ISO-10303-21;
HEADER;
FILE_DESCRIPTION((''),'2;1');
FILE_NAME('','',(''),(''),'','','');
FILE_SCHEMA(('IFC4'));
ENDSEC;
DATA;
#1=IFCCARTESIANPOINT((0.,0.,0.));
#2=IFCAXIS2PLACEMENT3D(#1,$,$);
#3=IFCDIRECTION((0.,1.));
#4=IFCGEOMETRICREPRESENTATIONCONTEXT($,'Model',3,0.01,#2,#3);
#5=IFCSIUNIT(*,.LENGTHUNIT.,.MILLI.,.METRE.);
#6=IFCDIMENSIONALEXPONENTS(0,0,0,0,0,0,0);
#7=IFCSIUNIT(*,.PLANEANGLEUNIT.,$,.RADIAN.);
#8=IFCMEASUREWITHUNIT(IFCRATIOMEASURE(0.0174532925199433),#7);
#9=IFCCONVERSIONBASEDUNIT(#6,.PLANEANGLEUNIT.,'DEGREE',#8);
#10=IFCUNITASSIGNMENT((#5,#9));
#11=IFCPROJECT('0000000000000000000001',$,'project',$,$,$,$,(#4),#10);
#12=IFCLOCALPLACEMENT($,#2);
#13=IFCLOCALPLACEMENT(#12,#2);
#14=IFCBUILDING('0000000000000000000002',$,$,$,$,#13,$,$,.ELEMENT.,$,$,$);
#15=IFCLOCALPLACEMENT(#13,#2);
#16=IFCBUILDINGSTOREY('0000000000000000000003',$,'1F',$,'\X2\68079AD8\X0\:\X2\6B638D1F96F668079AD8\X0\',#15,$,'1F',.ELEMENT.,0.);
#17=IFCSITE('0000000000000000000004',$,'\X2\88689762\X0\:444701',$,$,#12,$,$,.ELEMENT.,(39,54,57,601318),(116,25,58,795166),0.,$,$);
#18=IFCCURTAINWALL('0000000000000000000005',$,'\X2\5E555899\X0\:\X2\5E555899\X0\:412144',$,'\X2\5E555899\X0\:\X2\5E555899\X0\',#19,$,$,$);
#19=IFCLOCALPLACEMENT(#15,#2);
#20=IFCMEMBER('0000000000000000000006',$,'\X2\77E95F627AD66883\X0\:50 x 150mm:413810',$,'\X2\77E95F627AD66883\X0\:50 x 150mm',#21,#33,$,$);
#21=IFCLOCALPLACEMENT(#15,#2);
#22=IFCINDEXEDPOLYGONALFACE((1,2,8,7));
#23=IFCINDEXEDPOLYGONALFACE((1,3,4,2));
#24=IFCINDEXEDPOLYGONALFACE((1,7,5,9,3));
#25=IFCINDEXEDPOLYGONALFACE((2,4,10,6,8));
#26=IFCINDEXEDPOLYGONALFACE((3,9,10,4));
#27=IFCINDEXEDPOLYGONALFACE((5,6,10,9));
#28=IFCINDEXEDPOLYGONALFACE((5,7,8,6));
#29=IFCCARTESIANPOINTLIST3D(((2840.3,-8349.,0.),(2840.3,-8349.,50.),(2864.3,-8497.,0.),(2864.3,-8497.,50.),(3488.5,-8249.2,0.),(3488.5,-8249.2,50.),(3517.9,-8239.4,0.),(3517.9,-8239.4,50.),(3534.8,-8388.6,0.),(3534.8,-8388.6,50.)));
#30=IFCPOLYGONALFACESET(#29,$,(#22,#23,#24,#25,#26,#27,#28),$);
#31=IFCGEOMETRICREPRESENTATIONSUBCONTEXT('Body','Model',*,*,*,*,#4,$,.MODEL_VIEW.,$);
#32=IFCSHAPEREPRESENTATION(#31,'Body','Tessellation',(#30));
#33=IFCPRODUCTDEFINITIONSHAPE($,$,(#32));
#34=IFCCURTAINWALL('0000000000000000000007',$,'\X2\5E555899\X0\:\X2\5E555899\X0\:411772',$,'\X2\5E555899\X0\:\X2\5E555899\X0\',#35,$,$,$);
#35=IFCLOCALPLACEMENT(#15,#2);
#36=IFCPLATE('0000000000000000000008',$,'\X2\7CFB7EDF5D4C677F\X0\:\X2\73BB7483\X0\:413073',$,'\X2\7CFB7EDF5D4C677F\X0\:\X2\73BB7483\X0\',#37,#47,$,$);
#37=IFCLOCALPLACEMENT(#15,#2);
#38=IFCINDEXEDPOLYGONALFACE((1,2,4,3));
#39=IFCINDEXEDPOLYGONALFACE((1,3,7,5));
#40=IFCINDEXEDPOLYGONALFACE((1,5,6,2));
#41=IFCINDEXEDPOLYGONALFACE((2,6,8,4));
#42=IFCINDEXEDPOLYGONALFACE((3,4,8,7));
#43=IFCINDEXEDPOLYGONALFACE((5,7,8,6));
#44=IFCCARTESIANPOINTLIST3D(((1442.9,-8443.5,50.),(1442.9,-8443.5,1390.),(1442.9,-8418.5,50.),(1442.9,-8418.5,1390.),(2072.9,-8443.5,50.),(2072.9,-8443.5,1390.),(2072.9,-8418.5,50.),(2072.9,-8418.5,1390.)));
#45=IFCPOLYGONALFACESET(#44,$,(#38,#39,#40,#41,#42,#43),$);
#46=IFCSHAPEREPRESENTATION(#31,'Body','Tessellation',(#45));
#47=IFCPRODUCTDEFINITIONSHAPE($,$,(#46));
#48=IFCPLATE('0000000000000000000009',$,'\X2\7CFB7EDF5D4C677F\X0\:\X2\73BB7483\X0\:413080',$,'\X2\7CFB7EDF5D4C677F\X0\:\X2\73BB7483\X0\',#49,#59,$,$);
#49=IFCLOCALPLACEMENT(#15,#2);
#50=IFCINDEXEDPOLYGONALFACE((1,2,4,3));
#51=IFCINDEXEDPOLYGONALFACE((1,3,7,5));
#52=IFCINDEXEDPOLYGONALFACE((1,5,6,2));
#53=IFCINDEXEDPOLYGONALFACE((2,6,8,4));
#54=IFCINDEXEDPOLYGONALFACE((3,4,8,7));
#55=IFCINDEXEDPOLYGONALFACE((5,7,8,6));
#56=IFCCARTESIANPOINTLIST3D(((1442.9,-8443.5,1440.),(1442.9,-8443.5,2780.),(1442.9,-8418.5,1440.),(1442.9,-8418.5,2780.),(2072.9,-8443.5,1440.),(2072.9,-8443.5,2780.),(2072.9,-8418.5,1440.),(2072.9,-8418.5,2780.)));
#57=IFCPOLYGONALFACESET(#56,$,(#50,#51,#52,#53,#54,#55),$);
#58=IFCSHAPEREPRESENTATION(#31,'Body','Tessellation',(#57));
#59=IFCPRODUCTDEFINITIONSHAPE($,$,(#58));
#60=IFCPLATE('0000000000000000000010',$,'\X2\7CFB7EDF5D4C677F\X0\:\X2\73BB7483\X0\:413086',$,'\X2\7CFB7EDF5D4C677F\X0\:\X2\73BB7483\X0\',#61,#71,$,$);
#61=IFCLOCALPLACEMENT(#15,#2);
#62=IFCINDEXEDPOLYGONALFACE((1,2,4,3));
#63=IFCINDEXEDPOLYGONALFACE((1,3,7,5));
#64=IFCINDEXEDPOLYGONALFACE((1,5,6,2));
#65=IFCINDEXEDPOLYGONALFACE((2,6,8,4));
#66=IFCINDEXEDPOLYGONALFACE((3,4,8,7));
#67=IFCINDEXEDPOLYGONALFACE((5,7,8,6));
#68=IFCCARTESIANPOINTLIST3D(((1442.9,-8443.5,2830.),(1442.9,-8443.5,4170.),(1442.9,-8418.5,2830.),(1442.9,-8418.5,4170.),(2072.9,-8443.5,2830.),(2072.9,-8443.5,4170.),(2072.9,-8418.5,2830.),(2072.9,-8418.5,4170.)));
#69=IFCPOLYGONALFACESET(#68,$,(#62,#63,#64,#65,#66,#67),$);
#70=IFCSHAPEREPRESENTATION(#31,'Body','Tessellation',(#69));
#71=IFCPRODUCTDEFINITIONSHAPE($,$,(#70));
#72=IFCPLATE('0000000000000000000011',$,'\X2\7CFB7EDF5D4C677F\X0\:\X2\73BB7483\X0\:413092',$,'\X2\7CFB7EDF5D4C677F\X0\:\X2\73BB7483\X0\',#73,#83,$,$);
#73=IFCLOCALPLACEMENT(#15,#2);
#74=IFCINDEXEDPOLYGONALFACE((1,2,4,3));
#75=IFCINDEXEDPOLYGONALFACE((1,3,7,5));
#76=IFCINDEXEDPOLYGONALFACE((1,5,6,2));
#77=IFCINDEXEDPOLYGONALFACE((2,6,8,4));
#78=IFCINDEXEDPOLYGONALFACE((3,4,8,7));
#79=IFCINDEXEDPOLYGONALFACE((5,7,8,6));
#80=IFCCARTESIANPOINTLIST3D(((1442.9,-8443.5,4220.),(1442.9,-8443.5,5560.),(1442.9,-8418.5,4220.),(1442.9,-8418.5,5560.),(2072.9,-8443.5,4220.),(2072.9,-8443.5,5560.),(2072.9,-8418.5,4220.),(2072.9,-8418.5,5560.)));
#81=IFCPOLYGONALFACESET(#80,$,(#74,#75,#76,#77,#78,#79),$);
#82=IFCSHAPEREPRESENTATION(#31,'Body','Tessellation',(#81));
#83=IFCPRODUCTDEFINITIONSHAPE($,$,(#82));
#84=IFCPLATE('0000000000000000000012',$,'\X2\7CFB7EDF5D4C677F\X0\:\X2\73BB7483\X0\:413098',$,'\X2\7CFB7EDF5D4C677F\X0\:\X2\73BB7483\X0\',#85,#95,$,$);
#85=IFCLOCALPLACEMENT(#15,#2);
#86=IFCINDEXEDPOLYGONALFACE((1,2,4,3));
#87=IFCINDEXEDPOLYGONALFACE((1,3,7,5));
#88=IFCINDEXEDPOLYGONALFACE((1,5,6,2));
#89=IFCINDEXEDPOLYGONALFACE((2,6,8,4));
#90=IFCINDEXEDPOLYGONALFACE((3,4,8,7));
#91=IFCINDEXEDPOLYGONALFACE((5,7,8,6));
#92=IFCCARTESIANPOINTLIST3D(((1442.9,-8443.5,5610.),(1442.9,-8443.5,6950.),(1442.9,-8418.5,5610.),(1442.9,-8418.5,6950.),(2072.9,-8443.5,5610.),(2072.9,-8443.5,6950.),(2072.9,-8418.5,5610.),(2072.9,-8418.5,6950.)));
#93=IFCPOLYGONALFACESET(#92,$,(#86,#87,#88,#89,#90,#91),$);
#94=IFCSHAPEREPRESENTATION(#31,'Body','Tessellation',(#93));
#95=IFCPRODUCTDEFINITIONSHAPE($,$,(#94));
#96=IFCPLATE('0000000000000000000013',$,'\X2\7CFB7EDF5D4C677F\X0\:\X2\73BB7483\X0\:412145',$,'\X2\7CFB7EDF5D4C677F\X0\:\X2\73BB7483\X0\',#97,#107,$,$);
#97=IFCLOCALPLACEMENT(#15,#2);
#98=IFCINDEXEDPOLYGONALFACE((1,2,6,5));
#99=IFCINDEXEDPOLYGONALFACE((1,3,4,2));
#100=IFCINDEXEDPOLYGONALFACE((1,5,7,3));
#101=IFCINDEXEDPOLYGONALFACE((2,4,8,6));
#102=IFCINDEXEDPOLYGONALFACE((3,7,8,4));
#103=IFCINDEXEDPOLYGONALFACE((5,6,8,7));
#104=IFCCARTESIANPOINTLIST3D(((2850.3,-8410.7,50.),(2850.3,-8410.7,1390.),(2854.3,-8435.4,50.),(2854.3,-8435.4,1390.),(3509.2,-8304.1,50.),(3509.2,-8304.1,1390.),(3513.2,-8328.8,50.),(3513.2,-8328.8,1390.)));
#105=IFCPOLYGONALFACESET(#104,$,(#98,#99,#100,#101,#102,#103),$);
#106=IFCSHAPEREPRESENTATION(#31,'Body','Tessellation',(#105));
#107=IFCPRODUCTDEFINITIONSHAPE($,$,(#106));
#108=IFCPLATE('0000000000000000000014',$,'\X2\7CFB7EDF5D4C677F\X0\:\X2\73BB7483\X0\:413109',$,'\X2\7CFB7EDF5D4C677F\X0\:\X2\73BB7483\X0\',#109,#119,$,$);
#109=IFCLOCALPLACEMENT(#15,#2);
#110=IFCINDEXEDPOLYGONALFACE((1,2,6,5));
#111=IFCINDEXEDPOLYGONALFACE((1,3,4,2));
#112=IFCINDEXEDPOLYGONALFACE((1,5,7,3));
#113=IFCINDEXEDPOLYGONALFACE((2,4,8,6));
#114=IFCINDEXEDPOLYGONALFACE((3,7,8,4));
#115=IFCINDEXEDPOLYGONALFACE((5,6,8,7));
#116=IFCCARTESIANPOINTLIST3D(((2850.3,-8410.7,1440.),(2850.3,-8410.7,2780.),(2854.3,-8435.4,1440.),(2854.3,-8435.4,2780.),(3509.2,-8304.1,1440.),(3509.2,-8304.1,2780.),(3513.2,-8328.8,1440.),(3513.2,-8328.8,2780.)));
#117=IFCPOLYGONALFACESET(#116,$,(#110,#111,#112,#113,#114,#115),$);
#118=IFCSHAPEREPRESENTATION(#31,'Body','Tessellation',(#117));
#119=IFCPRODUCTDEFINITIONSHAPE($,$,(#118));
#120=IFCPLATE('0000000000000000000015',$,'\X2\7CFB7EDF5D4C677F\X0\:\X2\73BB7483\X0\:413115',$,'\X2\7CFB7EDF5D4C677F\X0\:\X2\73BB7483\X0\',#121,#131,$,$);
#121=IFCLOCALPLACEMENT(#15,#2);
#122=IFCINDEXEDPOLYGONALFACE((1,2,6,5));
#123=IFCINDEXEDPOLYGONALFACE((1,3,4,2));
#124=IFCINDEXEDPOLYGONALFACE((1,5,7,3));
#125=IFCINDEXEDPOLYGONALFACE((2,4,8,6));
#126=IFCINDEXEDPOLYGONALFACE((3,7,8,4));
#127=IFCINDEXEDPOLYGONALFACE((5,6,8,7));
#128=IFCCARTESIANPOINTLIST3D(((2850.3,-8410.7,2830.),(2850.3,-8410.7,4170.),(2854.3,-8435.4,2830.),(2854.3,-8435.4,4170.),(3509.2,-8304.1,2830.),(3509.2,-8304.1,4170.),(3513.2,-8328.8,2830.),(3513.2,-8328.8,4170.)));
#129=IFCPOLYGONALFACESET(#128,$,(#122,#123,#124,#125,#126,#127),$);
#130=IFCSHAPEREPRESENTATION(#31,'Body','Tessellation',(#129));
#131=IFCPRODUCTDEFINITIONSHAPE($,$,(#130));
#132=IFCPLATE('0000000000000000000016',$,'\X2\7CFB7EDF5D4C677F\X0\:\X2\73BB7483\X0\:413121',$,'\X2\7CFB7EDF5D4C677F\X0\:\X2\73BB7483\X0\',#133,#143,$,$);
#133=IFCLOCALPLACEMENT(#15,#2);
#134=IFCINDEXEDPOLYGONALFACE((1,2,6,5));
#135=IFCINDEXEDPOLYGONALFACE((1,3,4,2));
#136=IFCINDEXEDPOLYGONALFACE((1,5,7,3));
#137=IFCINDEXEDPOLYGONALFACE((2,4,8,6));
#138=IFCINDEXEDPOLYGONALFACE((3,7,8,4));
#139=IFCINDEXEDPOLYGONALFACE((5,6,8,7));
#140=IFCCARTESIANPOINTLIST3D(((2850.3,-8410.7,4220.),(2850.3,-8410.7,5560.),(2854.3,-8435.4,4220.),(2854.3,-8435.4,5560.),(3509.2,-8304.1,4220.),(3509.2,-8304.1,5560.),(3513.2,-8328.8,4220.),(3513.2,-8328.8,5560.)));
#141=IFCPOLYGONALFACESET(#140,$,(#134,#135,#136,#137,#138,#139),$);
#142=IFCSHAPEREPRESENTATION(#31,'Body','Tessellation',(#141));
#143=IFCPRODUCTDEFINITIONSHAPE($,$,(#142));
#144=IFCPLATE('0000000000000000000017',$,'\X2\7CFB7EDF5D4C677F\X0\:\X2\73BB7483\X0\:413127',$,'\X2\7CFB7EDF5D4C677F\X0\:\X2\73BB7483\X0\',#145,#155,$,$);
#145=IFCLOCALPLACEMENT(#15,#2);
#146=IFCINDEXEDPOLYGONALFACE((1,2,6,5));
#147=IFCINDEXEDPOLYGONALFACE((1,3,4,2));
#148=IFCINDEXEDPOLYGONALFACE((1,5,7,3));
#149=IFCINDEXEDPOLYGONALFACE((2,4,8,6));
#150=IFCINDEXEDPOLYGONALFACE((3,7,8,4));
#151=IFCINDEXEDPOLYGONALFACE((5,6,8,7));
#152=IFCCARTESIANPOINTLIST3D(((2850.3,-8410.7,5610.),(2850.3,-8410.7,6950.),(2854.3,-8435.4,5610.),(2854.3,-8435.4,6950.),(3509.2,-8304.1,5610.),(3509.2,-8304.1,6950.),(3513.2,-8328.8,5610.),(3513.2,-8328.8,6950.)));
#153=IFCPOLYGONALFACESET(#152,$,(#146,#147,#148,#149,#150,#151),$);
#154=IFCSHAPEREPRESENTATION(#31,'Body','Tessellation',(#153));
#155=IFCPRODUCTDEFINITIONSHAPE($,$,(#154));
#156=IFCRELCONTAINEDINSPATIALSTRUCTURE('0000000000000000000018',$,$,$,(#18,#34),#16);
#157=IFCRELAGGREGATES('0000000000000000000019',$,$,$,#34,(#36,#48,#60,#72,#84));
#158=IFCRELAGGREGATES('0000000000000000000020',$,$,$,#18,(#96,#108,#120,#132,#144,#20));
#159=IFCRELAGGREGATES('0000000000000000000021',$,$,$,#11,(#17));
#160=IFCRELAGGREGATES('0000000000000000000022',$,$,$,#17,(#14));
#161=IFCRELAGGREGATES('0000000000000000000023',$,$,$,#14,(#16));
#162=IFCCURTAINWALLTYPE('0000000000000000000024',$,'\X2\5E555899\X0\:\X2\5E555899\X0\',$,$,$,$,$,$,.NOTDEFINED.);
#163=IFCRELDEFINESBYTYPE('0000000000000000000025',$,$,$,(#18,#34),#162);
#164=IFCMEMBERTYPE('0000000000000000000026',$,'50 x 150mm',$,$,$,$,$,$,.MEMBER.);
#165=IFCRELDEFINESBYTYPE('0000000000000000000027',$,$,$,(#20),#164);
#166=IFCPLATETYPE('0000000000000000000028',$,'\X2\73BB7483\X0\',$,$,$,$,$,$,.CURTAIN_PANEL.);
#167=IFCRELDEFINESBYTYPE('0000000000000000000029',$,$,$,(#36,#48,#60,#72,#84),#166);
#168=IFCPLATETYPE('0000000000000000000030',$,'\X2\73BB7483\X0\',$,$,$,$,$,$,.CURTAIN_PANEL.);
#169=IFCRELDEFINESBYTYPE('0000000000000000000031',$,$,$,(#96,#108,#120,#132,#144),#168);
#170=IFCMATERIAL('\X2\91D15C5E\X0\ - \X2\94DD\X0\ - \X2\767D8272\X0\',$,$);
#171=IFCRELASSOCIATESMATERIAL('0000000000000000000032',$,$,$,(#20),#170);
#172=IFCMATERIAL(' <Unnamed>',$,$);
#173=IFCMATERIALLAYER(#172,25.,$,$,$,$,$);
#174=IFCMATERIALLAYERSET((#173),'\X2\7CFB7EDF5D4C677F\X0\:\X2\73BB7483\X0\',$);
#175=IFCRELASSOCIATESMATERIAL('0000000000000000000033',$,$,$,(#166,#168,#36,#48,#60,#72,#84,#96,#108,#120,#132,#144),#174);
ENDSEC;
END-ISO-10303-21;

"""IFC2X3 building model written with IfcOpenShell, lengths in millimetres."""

from ifc_helpers import new_model, entity, si_unit, converted_unit, direction, frame, frame_2d, origin, origin_2d_with_axis, place, context, subcontext, project, spatial, polyline, rectangle, extrude, clip, bounded_halfspace, source, transform, mapped, material, layer, layer_set, layer_usage, type_object, type_shapes, element, aggregate, save


model = new_model("IFC2X3")

# Units and contexts
model_context = context("Model", 3, precision=0.01, world=origin(), true_north=direction((0.0, 1.0)))
body_context = subcontext(model_context, "Body", "Model", "MODEL_VIEW")
ifc_project = project(units=[si_unit("LENGTHUNIT", "METRE", prefix="MILLI"), converted_unit("PLANEANGLEUNIT", "DEGREE", entity("IfcRatioMeasure", 0.0174532925199433), si_unit("PLANEANGLEUNIT", "RADIAN"), dimensions=[0, 0, 0, 0, 0, 0, 0])], contexts=[model_context])

# Site, building, storey
site_placement = place(None, origin())
site = spatial("IfcSite", under=ifc_project, at=site_placement, Name="表面:444701", CompositionType="ELEMENT", RefLatitude=(39, 54, 57, 601318), RefLongitude=(116, 25, 58, 795166), RefElevation=0.0)
building_placement = place(site_placement, origin())
building = spatial("IfcBuilding", under=site, at=building_placement, CompositionType="ELEMENT")
storey_placement = place(building_placement, origin())
storey = spatial("IfcBuildingStorey", under=building, at=storey_placement, Name="1F", ObjectType="标高:正负零标高", LongName="1F", CompositionType="ELEMENT", Elevation=0.0)

# Curtain wall, member
curtain_wall_type = type_object("IfcCurtainWallType", Name="幕墙:幕墙", PredefinedType="NOTDEFINED")
curtain_wall_1_placement = place(storey_placement, origin())
curtain_wall_1 = element("IfcCurtainWall", 1, at=curtain_wall_1_placement, inside=storey, type_object=curtain_wall_type, Name="幕墙:幕墙:412144", ObjectType="幕墙:幕墙")
ifc_material_1 = material(Name="金属 - 铝 - 白色")
member_type_1 = type_object("IfcMemberType", Name="50 x 150mm", PredefinedType="MEMBER")
shared_shape_1 = source(origin(), body_context, "Body", "Clipping", [
    clip(clip(extrude(rectangle(XDim=50.0, YDim=150.0, at=origin_2d_with_axis()), frame((-25.0, 0.0, -686.4)), (0.0, 0.0, 1.0), 686.4), bounded_halfspace(frame((0.0, 78.0, -679.7), z_axis=(0.0, -0.15966, -0.987172), x_axis=(-1.0, 0.0, 0.0)), False, frame((-25.0, 0.0, -686.4)), polyline([(25.0, 75.0), (25.0, -70.0), (-25.0, -70.0), (-25.0, 75.0), (25.0, 75.0)]))), bounded_halfspace(frame((0.0, -70.0, -655.8), z_axis=(0.0, 0.987172, -0.15966), x_axis=(-1.0, 0.0, 0.0)), False, frame((-25.0, 0.0, -686.4)), polyline([(25.0, -70.0), (25.0, -75.0), (-25.0, -75.0), (-25.0, -70.0), (25.0, -70.0)]))),
])
type_shapes(member_type_1, [shared_shape_1])
member_1_placement = place(storey_placement, frame((2852.3, -8423.0, 0.0), z_axis=(-0.987172, -0.15966, 0.0), x_axis=(0.0, 0.0, -1.0)))
member_1 = element("IfcMember", 2, at=member_1_placement, type_object=member_type_1, material=ifc_material_1, Name="矩形竖梃:50 x 150mm:413810", ObjectType="矩形竖梃:50 x 150mm", context=body_context, shape_type="MappedRepresentation", body=[
    mapped(shared_shape_1, transform((0.0, 0.0, 0.0), scale=1.0)),
])

# Curtain wall, plates
curtain_wall_2_placement = place(storey_placement, origin())
curtain_wall_2 = element("IfcCurtainWall", 3, at=curtain_wall_2_placement, inside=storey, type_object=curtain_wall_type, Name="幕墙:幕墙:411772", ObjectType="幕墙:幕墙")
ifc_material_2 = material(Name=" <Unnamed>")
ifc_layer = layer(ifc_material_2, 25.0)
ifc_layer_set = layer_set([ifc_layer], Name="系统嵌板:玻璃")
ifc_layer_usage_1 = layer_usage(ifc_layer_set, "AXIS3", "POSITIVE", 0.0)
plate_type_1 = type_object("IfcPlateType", Name="玻璃", PredefinedType="CURTAIN_PANEL", material=ifc_layer_set)
shared_shape_2 = source(origin(), body_context, "Body", "SweptSolid", [
    extrude(rectangle(XDim=25.0, YDim=630.0, at=origin_2d_with_axis()), frame((0.0, 0.0, 0.0), z_axis=(0.0, 0.0, 1.0), x_axis=(0.0, 1.0, 0.0)), (0.0, 0.0, 1.0), 1340.0),
])
type_shapes(plate_type_1, [shared_shape_2])
plate_1_placement = place(curtain_wall_2_placement, frame((1757.9, -8431.0, 50.0)))
plate_1 = element("IfcPlate", 4, at=plate_1_placement, type_object=plate_type_1, material=ifc_layer_usage_1, Name="系统嵌板:玻璃:413073", ObjectType="系统嵌板:玻璃", context=body_context, shape_type="MappedRepresentation", body=[
    mapped(shared_shape_2, transform((0.0, 0.0, 0.0), scale=1.0)),
])
ifc_layer_usage_2 = layer_usage(ifc_layer_set, "AXIS3", "POSITIVE", 0.0)
plate_2_placement = place(curtain_wall_2_placement, frame((1757.9, -8431.0, 1440.0)))
plate_2 = element("IfcPlate", 5, at=plate_2_placement, type_object=plate_type_1, material=ifc_layer_usage_2, Name="系统嵌板:玻璃:413080", ObjectType="系统嵌板:玻璃", context=body_context, shape_type="MappedRepresentation", body=[
    mapped(shared_shape_2, transform((0.0, 0.0, 0.0), scale=1.0)),
])
ifc_layer_usage_3 = layer_usage(ifc_layer_set, "AXIS3", "POSITIVE", 0.0)
plate_3_placement = place(curtain_wall_2_placement, frame((1757.9, -8431.0, 2830.0)))
plate_3 = element("IfcPlate", 6, at=plate_3_placement, type_object=plate_type_1, material=ifc_layer_usage_3, Name="系统嵌板:玻璃:413086", ObjectType="系统嵌板:玻璃", context=body_context, shape_type="MappedRepresentation", body=[
    mapped(shared_shape_2, transform((0.0, 0.0, 0.0), scale=1.0)),
])
ifc_layer_usage_4 = layer_usage(ifc_layer_set, "AXIS3", "POSITIVE", 0.0)
plate_4_placement = place(curtain_wall_2_placement, frame((1757.9, -8431.0, 4220.0)))
plate_4 = element("IfcPlate", 7, at=plate_4_placement, type_object=plate_type_1, material=ifc_layer_usage_4, Name="系统嵌板:玻璃:413092", ObjectType="系统嵌板:玻璃", context=body_context, shape_type="MappedRepresentation", body=[
    mapped(shared_shape_2, transform((0.0, 0.0, 0.0), scale=1.0)),
])
ifc_layer_usage_5 = layer_usage(ifc_layer_set, "AXIS3", "POSITIVE", 0.0)
plate_5_placement = place(curtain_wall_2_placement, frame((1757.9, -8431.0, 5610.0)))
plate_5 = element("IfcPlate", 8, at=plate_5_placement, type_object=plate_type_1, material=ifc_layer_usage_5, Name="系统嵌板:玻璃:413098", ObjectType="系统嵌板:玻璃", context=body_context, shape_type="MappedRepresentation", body=[
    mapped(shared_shape_2, transform((0.0, 0.0, 0.0), scale=1.0)),
])
aggregate(curtain_wall_2, [plate_1, plate_2, plate_3, plate_4, plate_5])

# Plates
ifc_layer_usage_6 = layer_usage(ifc_layer_set, "AXIS3", "POSITIVE", 0.0)
plate_type_2 = type_object("IfcPlateType", Name="玻璃", PredefinedType="CURTAIN_PANEL", material=ifc_layer_set)
shared_shape_3 = source(origin(), body_context, "Body", "SweptSolid", [
    extrude(rectangle(XDim=25.0, YDim=667.4, at=frame_2d((0.0, 0.0), x_axis=(1.0, 0.0))), frame((0.0, 0.0, 0.0), z_axis=(0.0, 0.0, 1.0), x_axis=(0.0, 1.0, 0.0)), (0.0, 0.0, 1.0), 1340.0),
])
type_shapes(plate_type_2, [shared_shape_3])
plate_6_placement = place(curtain_wall_1_placement, frame((3181.7, -8369.7, 50.0), z_axis=(0.0, 0.0, 1.0), x_axis=(0.987172, 0.15966, 0.0)))
plate_6 = element("IfcPlate", 9, at=plate_6_placement, type_object=plate_type_2, material=ifc_layer_usage_6, Name="系统嵌板:玻璃:412145", ObjectType="系统嵌板:玻璃", context=body_context, shape_type="MappedRepresentation", body=[
    mapped(shared_shape_3, transform((0.0, 0.0, 0.0), scale=1.0)),
])
ifc_layer_usage_7 = layer_usage(ifc_layer_set, "AXIS3", "POSITIVE", 0.0)
plate_7_placement = place(curtain_wall_1_placement, frame((3181.7, -8369.7, 1440.0), z_axis=(0.0, 0.0, 1.0), x_axis=(0.987172, 0.15966, 0.0)))
plate_7 = element("IfcPlate", 10, at=plate_7_placement, type_object=plate_type_2, material=ifc_layer_usage_7, Name="系统嵌板:玻璃:413109", ObjectType="系统嵌板:玻璃", context=body_context, shape_type="MappedRepresentation", body=[
    mapped(shared_shape_3, transform((0.0, 0.0, 0.0), scale=1.0)),
])
ifc_layer_usage_8 = layer_usage(ifc_layer_set, "AXIS3", "POSITIVE", 0.0)
plate_8_placement = place(curtain_wall_1_placement, frame((3181.7, -8369.7, 2830.0), z_axis=(0.0, 0.0, 1.0), x_axis=(0.987172, 0.15966, 0.0)))
plate_8 = element("IfcPlate", 11, at=plate_8_placement, type_object=plate_type_2, material=ifc_layer_usage_8, Name="系统嵌板:玻璃:413115", ObjectType="系统嵌板:玻璃", context=body_context, shape_type="MappedRepresentation", body=[
    mapped(shared_shape_3, transform((0.0, 0.0, 0.0), scale=1.0)),
])
ifc_layer_usage_9 = layer_usage(ifc_layer_set, "AXIS3", "POSITIVE", 0.0)
plate_9_placement = place(curtain_wall_1_placement, frame((3181.7, -8369.7, 4220.0), z_axis=(0.0, 0.0, 1.0), x_axis=(0.987172, 0.15966, 0.0)))
plate_9 = element("IfcPlate", 12, at=plate_9_placement, type_object=plate_type_2, material=ifc_layer_usage_9, Name="系统嵌板:玻璃:413121", ObjectType="系统嵌板:玻璃", context=body_context, shape_type="MappedRepresentation", body=[
    mapped(shared_shape_3, transform((0.0, 0.0, 0.0), scale=1.0)),
])
ifc_layer_usage_10 = layer_usage(ifc_layer_set, "AXIS3", "POSITIVE", 0.0)
plate_10_placement = place(curtain_wall_1_placement, frame((3181.7, -8369.7, 5610.0), z_axis=(0.0, 0.0, 1.0), x_axis=(0.987172, 0.15966, 0.0)))
plate_10 = element("IfcPlate", 13, at=plate_10_placement, type_object=plate_type_2, material=ifc_layer_usage_10, Name="系统嵌板:玻璃:413127", ObjectType="系统嵌板:玻璃", context=body_context, shape_type="MappedRepresentation", body=[
    mapped(shared_shape_3, transform((0.0, 0.0, 0.0), scale=1.0)),
])
aggregate(curtain_wall_1, [plate_6, plate_7, plate_8, plate_9, plate_10, member_1])

save(model, "model.ifc")
